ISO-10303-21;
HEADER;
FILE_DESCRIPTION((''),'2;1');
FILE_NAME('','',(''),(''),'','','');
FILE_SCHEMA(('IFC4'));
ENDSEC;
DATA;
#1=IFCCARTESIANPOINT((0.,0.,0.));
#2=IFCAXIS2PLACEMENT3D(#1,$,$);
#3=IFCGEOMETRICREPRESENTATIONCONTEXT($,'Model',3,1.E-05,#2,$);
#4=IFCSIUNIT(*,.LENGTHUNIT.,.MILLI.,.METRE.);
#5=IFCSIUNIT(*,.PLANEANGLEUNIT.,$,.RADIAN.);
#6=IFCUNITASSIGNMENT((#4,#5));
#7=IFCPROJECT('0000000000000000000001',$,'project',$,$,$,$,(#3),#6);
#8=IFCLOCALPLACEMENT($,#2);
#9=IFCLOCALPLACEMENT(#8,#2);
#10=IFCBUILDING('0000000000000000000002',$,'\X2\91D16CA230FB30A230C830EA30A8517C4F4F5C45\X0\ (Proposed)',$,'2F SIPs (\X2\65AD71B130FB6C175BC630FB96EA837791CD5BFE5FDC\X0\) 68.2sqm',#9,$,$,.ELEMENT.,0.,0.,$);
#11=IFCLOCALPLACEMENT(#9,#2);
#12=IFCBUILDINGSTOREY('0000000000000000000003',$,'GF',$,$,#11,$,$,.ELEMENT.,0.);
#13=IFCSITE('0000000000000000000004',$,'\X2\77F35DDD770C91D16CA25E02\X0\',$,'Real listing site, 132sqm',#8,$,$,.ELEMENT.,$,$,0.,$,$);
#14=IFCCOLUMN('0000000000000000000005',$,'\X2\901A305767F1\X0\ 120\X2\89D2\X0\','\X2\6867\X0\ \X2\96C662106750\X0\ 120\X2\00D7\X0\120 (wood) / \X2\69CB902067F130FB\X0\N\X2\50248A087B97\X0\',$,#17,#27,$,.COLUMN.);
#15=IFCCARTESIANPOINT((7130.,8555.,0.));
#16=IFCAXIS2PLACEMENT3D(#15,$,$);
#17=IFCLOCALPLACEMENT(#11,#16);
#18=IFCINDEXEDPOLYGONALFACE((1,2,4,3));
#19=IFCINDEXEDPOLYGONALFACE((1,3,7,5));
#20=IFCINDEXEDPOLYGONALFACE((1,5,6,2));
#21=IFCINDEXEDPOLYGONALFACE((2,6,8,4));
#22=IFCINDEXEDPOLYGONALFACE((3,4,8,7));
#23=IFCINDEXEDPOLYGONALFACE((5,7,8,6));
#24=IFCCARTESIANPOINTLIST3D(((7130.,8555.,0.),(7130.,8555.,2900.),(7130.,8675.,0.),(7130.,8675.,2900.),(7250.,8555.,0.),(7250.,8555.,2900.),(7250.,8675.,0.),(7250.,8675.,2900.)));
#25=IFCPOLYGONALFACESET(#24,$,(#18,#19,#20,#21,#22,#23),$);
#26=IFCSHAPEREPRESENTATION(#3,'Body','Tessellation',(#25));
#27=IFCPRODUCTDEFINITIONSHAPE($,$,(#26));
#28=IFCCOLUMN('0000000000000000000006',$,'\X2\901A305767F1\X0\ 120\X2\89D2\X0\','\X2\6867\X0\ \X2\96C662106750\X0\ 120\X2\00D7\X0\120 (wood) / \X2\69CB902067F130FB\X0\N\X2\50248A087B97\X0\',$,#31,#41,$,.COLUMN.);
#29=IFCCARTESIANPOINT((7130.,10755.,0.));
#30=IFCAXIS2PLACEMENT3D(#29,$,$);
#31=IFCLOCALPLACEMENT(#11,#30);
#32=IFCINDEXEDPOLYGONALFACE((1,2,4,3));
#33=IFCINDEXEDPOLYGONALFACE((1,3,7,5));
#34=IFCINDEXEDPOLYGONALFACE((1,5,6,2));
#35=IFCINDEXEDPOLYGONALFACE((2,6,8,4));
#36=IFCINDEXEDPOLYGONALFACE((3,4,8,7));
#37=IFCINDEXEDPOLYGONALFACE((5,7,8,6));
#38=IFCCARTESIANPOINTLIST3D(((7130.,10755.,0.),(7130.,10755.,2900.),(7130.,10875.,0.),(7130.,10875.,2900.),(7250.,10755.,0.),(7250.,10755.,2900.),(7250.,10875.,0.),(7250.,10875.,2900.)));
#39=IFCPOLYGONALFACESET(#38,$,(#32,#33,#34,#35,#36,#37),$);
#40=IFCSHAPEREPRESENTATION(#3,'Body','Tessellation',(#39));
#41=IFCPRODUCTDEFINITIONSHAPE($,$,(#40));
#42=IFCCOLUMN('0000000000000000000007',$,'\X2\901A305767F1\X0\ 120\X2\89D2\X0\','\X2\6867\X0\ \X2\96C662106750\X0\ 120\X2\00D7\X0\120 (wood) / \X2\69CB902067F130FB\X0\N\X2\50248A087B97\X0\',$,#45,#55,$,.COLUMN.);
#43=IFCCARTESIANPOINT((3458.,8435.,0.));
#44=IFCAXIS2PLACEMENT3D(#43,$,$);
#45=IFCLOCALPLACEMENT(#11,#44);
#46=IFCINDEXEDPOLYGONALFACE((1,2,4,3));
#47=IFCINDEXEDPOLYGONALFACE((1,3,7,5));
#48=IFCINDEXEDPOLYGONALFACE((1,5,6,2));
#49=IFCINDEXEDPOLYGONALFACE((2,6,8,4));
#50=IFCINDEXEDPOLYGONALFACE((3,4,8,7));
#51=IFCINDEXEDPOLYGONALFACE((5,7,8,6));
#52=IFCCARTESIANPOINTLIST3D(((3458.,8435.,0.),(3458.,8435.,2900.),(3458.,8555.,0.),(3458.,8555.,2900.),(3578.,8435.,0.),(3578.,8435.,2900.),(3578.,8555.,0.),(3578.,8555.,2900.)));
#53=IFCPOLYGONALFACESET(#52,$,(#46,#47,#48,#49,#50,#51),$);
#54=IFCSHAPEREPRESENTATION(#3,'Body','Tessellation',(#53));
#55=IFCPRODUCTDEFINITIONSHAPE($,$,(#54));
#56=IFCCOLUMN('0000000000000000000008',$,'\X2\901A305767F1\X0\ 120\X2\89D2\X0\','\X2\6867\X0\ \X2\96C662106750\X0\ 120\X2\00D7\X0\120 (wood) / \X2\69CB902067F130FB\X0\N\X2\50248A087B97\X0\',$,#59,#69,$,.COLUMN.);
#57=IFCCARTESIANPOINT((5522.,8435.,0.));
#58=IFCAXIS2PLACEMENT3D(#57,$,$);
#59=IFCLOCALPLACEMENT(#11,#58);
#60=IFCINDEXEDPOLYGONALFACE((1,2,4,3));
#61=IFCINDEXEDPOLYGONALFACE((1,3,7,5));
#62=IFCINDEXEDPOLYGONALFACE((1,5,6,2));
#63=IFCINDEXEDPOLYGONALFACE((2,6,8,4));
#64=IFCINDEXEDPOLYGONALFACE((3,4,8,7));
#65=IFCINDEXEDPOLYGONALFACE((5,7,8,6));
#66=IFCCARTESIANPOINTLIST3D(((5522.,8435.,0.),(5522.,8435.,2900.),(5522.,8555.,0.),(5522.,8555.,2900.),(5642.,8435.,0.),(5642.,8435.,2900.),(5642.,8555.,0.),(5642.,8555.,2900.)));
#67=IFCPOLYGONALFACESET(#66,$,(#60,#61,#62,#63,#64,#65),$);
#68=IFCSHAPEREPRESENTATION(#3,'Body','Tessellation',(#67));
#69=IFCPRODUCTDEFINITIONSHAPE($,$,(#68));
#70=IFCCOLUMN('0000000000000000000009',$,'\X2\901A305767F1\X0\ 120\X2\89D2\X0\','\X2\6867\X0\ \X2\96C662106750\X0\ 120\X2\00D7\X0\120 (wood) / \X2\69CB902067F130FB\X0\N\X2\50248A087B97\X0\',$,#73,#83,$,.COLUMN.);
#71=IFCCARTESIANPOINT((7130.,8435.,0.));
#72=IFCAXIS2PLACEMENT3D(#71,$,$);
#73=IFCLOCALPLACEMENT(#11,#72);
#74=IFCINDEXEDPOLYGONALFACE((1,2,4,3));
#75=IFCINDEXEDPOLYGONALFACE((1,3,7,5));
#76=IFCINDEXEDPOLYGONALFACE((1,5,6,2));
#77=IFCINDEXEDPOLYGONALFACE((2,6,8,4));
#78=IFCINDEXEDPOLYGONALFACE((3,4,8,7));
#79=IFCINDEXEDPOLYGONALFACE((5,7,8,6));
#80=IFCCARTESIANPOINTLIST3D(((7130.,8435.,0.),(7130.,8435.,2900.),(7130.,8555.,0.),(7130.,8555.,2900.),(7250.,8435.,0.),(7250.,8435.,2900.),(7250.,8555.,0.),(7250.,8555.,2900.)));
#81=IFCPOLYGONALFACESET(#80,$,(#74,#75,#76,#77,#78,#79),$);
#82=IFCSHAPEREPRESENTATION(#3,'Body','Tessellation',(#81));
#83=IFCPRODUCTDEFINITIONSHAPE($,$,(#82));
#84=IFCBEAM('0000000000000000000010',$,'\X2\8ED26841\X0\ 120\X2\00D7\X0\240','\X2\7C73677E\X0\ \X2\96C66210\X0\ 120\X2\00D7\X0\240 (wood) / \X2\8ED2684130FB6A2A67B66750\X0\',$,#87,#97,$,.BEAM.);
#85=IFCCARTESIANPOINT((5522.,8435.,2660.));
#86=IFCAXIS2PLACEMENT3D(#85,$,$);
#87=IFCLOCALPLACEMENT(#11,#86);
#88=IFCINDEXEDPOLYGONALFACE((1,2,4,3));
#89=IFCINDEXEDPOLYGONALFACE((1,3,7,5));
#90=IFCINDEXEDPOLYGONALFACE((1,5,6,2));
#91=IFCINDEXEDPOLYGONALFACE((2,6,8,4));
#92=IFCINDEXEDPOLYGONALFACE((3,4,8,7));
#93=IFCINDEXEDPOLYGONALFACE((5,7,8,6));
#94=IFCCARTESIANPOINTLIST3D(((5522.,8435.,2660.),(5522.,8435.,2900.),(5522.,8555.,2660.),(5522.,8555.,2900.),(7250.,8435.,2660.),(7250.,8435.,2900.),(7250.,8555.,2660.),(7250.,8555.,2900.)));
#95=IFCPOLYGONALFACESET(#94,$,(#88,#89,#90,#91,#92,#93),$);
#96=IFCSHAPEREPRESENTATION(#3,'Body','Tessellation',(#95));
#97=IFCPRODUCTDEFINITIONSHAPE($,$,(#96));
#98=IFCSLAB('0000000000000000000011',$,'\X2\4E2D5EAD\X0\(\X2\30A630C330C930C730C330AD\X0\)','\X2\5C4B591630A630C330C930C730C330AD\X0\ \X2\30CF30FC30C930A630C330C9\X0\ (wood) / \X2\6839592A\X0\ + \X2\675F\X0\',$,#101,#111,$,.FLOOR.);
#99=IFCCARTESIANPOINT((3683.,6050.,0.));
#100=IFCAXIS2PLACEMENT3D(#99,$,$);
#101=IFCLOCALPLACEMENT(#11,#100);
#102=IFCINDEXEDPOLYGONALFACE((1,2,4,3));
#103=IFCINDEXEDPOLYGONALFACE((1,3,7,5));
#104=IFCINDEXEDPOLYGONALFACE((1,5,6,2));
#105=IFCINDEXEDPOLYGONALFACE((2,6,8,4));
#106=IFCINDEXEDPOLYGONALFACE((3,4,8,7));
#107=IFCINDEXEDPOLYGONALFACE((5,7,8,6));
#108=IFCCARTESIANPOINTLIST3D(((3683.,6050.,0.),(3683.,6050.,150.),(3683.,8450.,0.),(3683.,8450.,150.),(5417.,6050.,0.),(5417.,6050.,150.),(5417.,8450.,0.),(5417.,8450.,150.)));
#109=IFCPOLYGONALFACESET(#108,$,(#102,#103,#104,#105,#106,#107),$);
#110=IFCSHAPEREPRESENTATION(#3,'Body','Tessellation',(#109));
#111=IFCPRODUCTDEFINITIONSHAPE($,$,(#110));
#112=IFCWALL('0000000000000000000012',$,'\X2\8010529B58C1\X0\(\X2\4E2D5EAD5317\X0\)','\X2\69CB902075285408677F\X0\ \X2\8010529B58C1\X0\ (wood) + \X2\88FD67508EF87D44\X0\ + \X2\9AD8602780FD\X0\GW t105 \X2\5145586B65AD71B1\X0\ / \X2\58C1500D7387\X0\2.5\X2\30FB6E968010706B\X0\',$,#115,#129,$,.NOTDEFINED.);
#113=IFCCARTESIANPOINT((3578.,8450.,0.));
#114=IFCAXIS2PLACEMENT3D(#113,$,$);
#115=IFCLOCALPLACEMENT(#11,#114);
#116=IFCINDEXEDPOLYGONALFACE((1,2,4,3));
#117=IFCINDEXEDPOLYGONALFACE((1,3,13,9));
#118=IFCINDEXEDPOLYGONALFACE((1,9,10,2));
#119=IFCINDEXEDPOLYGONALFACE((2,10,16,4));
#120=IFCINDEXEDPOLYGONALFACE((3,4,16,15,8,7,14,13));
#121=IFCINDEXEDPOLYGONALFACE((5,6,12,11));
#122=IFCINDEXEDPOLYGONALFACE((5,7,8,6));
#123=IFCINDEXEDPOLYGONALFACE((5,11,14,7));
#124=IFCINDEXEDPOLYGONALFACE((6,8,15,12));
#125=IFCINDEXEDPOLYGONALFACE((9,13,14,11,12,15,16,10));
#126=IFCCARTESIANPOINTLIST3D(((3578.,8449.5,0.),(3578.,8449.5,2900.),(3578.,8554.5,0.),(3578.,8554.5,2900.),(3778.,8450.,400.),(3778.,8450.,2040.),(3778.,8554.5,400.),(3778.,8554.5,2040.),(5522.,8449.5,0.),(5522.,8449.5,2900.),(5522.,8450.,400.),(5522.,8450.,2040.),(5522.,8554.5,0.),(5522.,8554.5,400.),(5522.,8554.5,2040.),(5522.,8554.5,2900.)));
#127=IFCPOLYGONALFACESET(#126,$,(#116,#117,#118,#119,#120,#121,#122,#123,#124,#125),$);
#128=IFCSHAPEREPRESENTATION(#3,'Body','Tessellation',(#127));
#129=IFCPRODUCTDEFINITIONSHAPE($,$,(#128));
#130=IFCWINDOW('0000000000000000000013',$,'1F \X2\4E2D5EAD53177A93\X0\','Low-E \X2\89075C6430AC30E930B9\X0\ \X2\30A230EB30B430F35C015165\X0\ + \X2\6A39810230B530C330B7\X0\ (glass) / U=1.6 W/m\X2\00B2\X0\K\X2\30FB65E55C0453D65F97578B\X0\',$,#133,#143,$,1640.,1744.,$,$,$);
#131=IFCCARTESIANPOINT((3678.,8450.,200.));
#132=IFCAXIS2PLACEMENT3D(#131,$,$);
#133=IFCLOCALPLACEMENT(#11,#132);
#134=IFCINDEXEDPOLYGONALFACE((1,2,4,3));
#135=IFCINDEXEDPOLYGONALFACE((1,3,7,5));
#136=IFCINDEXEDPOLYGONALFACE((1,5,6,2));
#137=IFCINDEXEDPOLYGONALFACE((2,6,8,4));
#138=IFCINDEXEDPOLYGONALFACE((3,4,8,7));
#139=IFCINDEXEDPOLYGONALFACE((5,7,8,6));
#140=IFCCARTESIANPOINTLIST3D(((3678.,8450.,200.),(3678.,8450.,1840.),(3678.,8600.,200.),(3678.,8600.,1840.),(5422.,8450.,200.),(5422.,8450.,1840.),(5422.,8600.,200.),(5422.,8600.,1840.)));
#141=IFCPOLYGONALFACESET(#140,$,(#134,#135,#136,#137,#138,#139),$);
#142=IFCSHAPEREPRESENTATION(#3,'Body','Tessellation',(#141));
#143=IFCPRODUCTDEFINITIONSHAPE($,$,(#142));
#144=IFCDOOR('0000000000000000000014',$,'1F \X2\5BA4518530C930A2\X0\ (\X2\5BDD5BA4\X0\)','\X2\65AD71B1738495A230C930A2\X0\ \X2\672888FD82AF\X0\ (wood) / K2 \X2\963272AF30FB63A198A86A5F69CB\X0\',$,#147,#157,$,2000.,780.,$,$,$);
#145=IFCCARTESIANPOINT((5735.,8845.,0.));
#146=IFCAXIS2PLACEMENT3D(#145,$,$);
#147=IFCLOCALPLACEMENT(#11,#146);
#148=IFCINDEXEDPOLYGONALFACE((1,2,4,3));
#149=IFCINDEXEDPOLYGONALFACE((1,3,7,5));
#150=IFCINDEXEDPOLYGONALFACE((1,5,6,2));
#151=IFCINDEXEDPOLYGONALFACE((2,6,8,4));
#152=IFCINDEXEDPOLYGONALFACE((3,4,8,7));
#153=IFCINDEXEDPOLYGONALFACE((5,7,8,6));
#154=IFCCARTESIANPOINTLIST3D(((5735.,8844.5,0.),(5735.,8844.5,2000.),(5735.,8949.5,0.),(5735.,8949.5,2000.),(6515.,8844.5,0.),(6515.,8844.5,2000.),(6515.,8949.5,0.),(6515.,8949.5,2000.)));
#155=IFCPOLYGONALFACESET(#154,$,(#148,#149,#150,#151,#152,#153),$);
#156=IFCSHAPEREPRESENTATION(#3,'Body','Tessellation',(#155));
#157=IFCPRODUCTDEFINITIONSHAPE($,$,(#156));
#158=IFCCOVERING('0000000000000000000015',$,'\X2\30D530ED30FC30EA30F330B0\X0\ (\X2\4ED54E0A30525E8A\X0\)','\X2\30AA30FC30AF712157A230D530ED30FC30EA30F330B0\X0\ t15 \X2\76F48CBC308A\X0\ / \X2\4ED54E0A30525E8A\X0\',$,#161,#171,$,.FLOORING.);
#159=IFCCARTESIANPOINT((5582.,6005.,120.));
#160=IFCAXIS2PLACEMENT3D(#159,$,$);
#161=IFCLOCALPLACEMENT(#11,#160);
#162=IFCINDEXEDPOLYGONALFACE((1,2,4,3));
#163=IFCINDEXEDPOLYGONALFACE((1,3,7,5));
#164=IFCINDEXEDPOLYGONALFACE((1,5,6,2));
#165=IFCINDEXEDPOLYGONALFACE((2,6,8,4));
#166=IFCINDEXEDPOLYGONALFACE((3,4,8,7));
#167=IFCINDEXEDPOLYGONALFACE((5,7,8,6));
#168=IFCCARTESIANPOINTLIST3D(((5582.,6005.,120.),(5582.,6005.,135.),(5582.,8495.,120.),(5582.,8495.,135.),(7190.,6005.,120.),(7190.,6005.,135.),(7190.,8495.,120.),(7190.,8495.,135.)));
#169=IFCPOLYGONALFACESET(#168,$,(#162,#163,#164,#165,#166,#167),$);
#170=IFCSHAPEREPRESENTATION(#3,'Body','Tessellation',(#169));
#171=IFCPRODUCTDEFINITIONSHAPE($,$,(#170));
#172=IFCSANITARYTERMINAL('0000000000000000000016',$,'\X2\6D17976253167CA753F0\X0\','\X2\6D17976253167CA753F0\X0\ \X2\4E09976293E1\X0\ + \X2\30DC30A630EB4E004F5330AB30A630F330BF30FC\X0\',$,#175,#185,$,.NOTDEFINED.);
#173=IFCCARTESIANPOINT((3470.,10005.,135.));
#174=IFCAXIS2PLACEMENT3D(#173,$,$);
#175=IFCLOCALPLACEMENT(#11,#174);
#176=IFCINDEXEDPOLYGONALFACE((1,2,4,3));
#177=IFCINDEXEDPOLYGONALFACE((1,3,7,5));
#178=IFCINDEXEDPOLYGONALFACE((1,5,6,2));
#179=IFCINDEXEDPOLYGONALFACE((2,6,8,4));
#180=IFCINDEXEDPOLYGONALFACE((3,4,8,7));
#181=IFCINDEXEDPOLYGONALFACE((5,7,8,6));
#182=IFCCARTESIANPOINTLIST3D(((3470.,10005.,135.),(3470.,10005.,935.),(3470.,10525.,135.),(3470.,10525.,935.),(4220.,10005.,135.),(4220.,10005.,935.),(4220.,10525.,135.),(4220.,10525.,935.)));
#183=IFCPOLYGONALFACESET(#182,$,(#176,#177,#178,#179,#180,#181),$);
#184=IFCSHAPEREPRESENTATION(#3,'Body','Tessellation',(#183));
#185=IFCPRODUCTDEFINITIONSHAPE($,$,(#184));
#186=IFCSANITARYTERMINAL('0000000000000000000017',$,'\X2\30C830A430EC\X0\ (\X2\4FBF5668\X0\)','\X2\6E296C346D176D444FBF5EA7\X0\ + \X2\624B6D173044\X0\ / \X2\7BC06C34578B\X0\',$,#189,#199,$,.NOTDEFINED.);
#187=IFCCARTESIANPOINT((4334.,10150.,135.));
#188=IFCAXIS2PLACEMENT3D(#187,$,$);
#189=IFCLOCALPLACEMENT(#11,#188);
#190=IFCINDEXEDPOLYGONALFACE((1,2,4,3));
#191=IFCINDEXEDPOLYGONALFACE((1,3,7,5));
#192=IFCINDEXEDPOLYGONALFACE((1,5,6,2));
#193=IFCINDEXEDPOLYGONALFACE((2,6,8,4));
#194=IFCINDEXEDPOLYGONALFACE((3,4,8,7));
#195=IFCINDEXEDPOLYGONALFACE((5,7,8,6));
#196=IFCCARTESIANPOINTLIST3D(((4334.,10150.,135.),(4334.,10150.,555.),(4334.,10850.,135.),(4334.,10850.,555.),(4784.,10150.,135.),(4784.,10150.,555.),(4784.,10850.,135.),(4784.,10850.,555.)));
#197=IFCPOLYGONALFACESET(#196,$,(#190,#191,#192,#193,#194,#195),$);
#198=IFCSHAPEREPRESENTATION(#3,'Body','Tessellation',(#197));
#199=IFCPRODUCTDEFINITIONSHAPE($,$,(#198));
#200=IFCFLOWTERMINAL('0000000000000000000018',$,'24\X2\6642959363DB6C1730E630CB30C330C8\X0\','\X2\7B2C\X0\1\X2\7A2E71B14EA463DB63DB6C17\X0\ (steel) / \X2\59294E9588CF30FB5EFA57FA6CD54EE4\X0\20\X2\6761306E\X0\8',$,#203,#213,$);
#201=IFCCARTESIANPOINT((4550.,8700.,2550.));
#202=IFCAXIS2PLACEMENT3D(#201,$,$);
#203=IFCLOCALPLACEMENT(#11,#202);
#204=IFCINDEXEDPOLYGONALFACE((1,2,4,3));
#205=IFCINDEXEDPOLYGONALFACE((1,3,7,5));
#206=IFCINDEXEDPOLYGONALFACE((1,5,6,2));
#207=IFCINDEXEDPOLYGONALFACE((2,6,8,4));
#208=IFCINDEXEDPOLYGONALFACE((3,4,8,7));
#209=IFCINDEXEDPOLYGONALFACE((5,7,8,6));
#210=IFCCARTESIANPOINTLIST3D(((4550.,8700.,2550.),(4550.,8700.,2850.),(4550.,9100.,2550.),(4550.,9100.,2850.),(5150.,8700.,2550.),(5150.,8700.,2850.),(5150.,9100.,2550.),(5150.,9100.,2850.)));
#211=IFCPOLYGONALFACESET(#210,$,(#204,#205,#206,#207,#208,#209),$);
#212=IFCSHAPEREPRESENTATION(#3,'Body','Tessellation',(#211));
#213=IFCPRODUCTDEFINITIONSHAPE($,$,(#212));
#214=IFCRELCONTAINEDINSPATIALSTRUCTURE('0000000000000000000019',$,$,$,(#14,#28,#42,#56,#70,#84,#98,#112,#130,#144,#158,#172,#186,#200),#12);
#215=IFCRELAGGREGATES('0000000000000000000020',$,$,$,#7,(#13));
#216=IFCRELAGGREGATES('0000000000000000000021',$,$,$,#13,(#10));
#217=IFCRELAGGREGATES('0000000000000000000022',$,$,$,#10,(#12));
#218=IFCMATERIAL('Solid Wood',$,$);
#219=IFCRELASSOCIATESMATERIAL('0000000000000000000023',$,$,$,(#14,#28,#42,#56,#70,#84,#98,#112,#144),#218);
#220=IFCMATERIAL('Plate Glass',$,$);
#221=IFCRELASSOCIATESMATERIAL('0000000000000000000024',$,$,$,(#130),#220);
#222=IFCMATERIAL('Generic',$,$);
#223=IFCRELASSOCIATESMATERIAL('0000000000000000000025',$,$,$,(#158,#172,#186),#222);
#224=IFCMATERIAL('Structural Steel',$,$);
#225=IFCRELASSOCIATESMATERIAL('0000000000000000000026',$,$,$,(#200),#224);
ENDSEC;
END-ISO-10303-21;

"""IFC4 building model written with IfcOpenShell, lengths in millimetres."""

from ifc_helpers import new_model, si_unit, frame, frame_2d, origin, place, context, project, spatial, rectangle, extrude, material, element, fill, save


model = new_model("IFC4")

# Units and contexts
model_context = context("Model", 3, precision=1e-05, world=origin())
ifc_project = project(units=[si_unit("LENGTHUNIT", "METRE", prefix="MILLI"), si_unit("PLANEANGLEUNIT", "RADIAN")], contexts=[model_context])

# Site, building, storey
site_placement = place(None, origin())
site = spatial("IfcSite", under=ifc_project, at=site_placement, Name="石川県金沢市", ObjectType="Real listing site, 132sqm", CompositionType="ELEMENT", RefElevation=0.0)
building_placement = place(site_placement, origin())
building = spatial("IfcBuilding", under=site, at=building_placement, Name="金沢・アトリエ兼住居 (Proposed)", ObjectType="2F SIPs (断熱・気密・雪荷重対応) 68.2sqm", CompositionType="ELEMENT", ElevationOfRefHeight=0.0, ElevationOfTerrain=0.0)
storey_placement = place(building_placement, origin())
storey = spatial("IfcBuildingStorey", under=building, at=storey_placement, Name="GF", CompositionType="ELEMENT", Elevation=0.0)

# Columns
ifc_material_1 = material(Name="Solid Wood")
column_1_placement = place(storey_placement, frame((7130.0, 8555.0, 0.0)))
element("IfcColumn", 1, at=column_1_placement, inside=storey, material=ifc_material_1, Name="通し柱 120角", Description="桧 集成材 120×120 (wood) / 構造柱・N値計算", PredefinedType="COLUMN", context=model_context, shape_type="SweptSolid", body=[
    extrude(rectangle(XDim=120.0, YDim=120.0, at=frame_2d((60.0, 60.0))), frame((7130.0, 8555.0, 0.0)), (0.0, 0.0, 1.0), 2900.0),
])
column_2_placement = place(storey_placement, frame((7130.0, 10755.0, 0.0)))
element("IfcColumn", 2, at=column_2_placement, inside=storey, material=ifc_material_1, Name="通し柱 120角", Description="桧 集成材 120×120 (wood) / 構造柱・N値計算", PredefinedType="COLUMN", context=model_context, shape_type="SweptSolid", body=[
    extrude(rectangle(XDim=120.0, YDim=120.0, at=frame_2d((60.0, 60.0))), frame((7130.0, 10755.0, 0.0)), (0.0, 0.0, 1.0), 2900.0),
])
column_3_placement = place(storey_placement, frame((3458.0, 8435.0, 0.0)))
element("IfcColumn", 3, at=column_3_placement, inside=storey, material=ifc_material_1, Name="通し柱 120角", Description="桧 集成材 120×120 (wood) / 構造柱・N値計算", PredefinedType="COLUMN", context=model_context, shape_type="SweptSolid", body=[
    extrude(rectangle(XDim=120.0, YDim=120.0, at=frame_2d((60.0, 60.0))), frame((3458.0, 8435.0, 0.0)), (0.0, 0.0, 1.0), 2900.0),
])
column_4_placement = place(storey_placement, frame((5522.0, 8435.0, 0.0)))
element("IfcColumn", 4, at=column_4_placement, inside=storey, material=ifc_material_1, Name="通し柱 120角", Description="桧 集成材 120×120 (wood) / 構造柱・N値計算", PredefinedType="COLUMN", context=model_context, shape_type="SweptSolid", body=[
    extrude(rectangle(XDim=120.0, YDim=120.0, at=frame_2d((60.0, 60.0))), frame((5522.0, 8435.0, 0.0)), (0.0, 0.0, 1.0), 2900.0),
])
column_5_placement = place(storey_placement, frame((7130.0, 8435.0, 0.0)))
element("IfcColumn", 5, at=column_5_placement, inside=storey, material=ifc_material_1, Name="通し柱 120角", Description="桧 集成材 120×120 (wood) / 構造柱・N値計算", PredefinedType="COLUMN", context=model_context, shape_type="SweptSolid", body=[
    extrude(rectangle(XDim=120.0, YDim=120.0, at=frame_2d((60.0, 60.0))), frame((7130.0, 8435.0, 0.0)), (0.0, 0.0, 1.0), 2900.0),
])

# Beam
beam_1_placement = place(storey_placement, frame((5522.0, 8435.0, 2660.0)))
element("IfcBeam", 6, at=beam_1_placement, inside=storey, material=ifc_material_1, Name="軒桁 120×240", Description="米松 集成 120×240 (wood) / 軒桁・横架材", PredefinedType="BEAM", context=model_context, shape_type="SweptSolid", body=[
    extrude(rectangle(XDim=1728.0, YDim=120.0, at=frame_2d((864.0, 60.0))), frame((5522.0, 8435.0, 2660.0)), (0.0, 0.0, 1.0), 240.0),
])

# Slab
slab_placement = place(storey_placement, frame((3683.0, 6050.0, 0.0)))
element("IfcSlab", 7, at=slab_placement, inside=storey, material=ifc_material_1, Name="中庭(ウッドデッキ)", Description="屋外ウッドデッキ ハードウッド (wood) / 根太 + 束", PredefinedType="FLOOR", context=model_context, shape_type="SweptSolid", body=[
    extrude(rectangle(XDim=1734.0, YDim=2400.0, at=frame_2d((867.0, 1200.0))), frame((3683.0, 6050.0, 0.0)), (0.0, 0.0, 1.0), 150.0),
])

# Wall, opening, window
wall_1_placement = place(storey_placement, frame((3578.0, 8450.0, 0.0)))
wall_1 = element("IfcWall", 8, at=wall_1_placement, inside=storey, material=ifc_material_1, Name="耐力壁(中庭北)", Description="構造用合板 耐力壁 (wood) + 製材軸組 + 高性能GW t105 充填断熱 / 壁倍率2.5・準耐火", PredefinedType="NOTDEFINED", context=model_context, shape_type="SweptSolid", body=[
    extrude(rectangle(XDim=1944.0, YDim=105.0, at=frame_2d((972.0, 52.0))), frame((3578.0, 8450.0, 0.0)), (0.0, 0.0, 1.0), 2900.0),
])
opening_placement = place(storey_placement, frame((3678.0, 8450.0, 200.0)))
opening = element("IfcOpeningElement", 9, at=opening_placement, cuts=wall_1, PredefinedType="NOTDEFINED", context=model_context, shape_type="SweptSolid", body=[
    extrude(rectangle(XDim=1744.0, YDim=150.0, at=frame_2d((872.0, 75.0))), frame((3678.0, 8450.0, 200.0)), (0.0, 0.0, 1.0), 1640.0),
])
ifc_material_2 = material(Name="Plate Glass")
window_placement = place(storey_placement, frame((3678.0, 8450.0, 200.0)))
window = element("IfcWindow", 10, at=window_placement, inside=storey, material=ifc_material_2, Name="1F 中庭北窓", Description="Low-E 複層ガラス アルゴン封入 + 樹脂サッシ (glass) / U=1.6 W/m²K・日射取得型", OverallHeight=1640.0, OverallWidth=1744.0, context=model_context, shape_type="SweptSolid", body=[
    extrude(rectangle(XDim=1744.0, YDim=150.0, at=frame_2d((872.0, 75.0))), frame((3678.0, 8450.0, 200.0)), (0.0, 0.0, 1.0), 1640.0),
])
fill(opening, window)

# Door
door_placement = place(storey_placement, frame((5735.0, 8845.0, 0.0)))
element("IfcDoor", 11, at=door_placement, inside=storey, material=ifc_material_1, Name="1F 室内ドア (寝室)", Description="断熱玄関ドア 木製芯 (wood) / K2 防犯・採風機構", OverallHeight=2000.0, OverallWidth=780.0, context=model_context, shape_type="SweptSolid", body=[
    extrude(rectangle(XDim=780.0, YDim=105.0, at=frame_2d((390.0, 52.0))), frame((5735.0, 8845.0, 0.0)), (0.0, 0.0, 1.0), 2000.0),
])

# Covering
ifc_material_3 = material(Name="Generic")
covering_placement = place(storey_placement, frame((5582.0, 6005.0, 120.0)))
element("IfcCovering", 12, at=covering_placement, inside=storey, material=ifc_material_3, Name="フローリング (仕上げ床)", Description="オーク無垢フローリング t15 直貼り / 仕上げ床", PredefinedType="FLOORING", context=model_context, shape_type="SweptSolid", body=[
    extrude(rectangle(XDim=1608.0, YDim=2490.0, at=frame_2d((804.0, 1245.0))), frame((5582.0, 6005.0, 120.0)), (0.0, 0.0, 1.0), 15.0),
])

# Sanitary terminals
sanitary_terminal_1_placement = place(storey_placement, frame((3470.0, 10005.0, 135.0)))
element("IfcSanitaryTerminal", 13, at=sanitary_terminal_1_placement, inside=storey, material=ifc_material_3, Name="洗面化粧台", Description="洗面化粧台 三面鏡 + ボウル一体カウンター", PredefinedType="NOTDEFINED", context=model_context, shape_type="SweptSolid", body=[
    extrude(rectangle(XDim=750.0, YDim=520.0, at=frame_2d((375.0, 260.0))), frame((3470.0, 10005.0, 135.0)), (0.0, 0.0, 1.0), 800.0),
])
sanitary_terminal_2_placement = place(storey_placement, frame((4334.0, 10150.0, 135.0)))
element("IfcSanitaryTerminal", 14, at=sanitary_terminal_2_placement, inside=storey, material=ifc_material_3, Name="トイレ (便器)", Description="温水洗浄便座 + 手洗い / 節水型", PredefinedType="NOTDEFINED", context=model_context, shape_type="SweptSolid", body=[
    extrude(rectangle(XDim=450.0, YDim=700.0, at=frame_2d((225.0, 350.0))), frame((4334.0, 10150.0, 135.0)), (0.0, 0.0, 1.0), 420.0),
])

# Flow terminal
ifc_material_4 = material(Name="Structural Steel")
flow_terminal_placement = place(storey_placement, frame((4550.0, 8700.0, 2550.0)))
element("IfcFlowTerminal", 15, at=flow_terminal_placement, inside=storey, material=ifc_material_4, Name="24時間換気ユニット", Description="第1種熱交換換気 (steel) / 天井裏・建基法令20条の8", context=model_context, shape_type="SweptSolid", body=[
    extrude(rectangle(XDim=600.0, YDim=400.0, at=frame_2d((300.0, 200.0))), frame((4550.0, 8700.0, 2550.0)), (0.0, 0.0, 1.0), 300.0),
])

save(model, "model.ifc")
